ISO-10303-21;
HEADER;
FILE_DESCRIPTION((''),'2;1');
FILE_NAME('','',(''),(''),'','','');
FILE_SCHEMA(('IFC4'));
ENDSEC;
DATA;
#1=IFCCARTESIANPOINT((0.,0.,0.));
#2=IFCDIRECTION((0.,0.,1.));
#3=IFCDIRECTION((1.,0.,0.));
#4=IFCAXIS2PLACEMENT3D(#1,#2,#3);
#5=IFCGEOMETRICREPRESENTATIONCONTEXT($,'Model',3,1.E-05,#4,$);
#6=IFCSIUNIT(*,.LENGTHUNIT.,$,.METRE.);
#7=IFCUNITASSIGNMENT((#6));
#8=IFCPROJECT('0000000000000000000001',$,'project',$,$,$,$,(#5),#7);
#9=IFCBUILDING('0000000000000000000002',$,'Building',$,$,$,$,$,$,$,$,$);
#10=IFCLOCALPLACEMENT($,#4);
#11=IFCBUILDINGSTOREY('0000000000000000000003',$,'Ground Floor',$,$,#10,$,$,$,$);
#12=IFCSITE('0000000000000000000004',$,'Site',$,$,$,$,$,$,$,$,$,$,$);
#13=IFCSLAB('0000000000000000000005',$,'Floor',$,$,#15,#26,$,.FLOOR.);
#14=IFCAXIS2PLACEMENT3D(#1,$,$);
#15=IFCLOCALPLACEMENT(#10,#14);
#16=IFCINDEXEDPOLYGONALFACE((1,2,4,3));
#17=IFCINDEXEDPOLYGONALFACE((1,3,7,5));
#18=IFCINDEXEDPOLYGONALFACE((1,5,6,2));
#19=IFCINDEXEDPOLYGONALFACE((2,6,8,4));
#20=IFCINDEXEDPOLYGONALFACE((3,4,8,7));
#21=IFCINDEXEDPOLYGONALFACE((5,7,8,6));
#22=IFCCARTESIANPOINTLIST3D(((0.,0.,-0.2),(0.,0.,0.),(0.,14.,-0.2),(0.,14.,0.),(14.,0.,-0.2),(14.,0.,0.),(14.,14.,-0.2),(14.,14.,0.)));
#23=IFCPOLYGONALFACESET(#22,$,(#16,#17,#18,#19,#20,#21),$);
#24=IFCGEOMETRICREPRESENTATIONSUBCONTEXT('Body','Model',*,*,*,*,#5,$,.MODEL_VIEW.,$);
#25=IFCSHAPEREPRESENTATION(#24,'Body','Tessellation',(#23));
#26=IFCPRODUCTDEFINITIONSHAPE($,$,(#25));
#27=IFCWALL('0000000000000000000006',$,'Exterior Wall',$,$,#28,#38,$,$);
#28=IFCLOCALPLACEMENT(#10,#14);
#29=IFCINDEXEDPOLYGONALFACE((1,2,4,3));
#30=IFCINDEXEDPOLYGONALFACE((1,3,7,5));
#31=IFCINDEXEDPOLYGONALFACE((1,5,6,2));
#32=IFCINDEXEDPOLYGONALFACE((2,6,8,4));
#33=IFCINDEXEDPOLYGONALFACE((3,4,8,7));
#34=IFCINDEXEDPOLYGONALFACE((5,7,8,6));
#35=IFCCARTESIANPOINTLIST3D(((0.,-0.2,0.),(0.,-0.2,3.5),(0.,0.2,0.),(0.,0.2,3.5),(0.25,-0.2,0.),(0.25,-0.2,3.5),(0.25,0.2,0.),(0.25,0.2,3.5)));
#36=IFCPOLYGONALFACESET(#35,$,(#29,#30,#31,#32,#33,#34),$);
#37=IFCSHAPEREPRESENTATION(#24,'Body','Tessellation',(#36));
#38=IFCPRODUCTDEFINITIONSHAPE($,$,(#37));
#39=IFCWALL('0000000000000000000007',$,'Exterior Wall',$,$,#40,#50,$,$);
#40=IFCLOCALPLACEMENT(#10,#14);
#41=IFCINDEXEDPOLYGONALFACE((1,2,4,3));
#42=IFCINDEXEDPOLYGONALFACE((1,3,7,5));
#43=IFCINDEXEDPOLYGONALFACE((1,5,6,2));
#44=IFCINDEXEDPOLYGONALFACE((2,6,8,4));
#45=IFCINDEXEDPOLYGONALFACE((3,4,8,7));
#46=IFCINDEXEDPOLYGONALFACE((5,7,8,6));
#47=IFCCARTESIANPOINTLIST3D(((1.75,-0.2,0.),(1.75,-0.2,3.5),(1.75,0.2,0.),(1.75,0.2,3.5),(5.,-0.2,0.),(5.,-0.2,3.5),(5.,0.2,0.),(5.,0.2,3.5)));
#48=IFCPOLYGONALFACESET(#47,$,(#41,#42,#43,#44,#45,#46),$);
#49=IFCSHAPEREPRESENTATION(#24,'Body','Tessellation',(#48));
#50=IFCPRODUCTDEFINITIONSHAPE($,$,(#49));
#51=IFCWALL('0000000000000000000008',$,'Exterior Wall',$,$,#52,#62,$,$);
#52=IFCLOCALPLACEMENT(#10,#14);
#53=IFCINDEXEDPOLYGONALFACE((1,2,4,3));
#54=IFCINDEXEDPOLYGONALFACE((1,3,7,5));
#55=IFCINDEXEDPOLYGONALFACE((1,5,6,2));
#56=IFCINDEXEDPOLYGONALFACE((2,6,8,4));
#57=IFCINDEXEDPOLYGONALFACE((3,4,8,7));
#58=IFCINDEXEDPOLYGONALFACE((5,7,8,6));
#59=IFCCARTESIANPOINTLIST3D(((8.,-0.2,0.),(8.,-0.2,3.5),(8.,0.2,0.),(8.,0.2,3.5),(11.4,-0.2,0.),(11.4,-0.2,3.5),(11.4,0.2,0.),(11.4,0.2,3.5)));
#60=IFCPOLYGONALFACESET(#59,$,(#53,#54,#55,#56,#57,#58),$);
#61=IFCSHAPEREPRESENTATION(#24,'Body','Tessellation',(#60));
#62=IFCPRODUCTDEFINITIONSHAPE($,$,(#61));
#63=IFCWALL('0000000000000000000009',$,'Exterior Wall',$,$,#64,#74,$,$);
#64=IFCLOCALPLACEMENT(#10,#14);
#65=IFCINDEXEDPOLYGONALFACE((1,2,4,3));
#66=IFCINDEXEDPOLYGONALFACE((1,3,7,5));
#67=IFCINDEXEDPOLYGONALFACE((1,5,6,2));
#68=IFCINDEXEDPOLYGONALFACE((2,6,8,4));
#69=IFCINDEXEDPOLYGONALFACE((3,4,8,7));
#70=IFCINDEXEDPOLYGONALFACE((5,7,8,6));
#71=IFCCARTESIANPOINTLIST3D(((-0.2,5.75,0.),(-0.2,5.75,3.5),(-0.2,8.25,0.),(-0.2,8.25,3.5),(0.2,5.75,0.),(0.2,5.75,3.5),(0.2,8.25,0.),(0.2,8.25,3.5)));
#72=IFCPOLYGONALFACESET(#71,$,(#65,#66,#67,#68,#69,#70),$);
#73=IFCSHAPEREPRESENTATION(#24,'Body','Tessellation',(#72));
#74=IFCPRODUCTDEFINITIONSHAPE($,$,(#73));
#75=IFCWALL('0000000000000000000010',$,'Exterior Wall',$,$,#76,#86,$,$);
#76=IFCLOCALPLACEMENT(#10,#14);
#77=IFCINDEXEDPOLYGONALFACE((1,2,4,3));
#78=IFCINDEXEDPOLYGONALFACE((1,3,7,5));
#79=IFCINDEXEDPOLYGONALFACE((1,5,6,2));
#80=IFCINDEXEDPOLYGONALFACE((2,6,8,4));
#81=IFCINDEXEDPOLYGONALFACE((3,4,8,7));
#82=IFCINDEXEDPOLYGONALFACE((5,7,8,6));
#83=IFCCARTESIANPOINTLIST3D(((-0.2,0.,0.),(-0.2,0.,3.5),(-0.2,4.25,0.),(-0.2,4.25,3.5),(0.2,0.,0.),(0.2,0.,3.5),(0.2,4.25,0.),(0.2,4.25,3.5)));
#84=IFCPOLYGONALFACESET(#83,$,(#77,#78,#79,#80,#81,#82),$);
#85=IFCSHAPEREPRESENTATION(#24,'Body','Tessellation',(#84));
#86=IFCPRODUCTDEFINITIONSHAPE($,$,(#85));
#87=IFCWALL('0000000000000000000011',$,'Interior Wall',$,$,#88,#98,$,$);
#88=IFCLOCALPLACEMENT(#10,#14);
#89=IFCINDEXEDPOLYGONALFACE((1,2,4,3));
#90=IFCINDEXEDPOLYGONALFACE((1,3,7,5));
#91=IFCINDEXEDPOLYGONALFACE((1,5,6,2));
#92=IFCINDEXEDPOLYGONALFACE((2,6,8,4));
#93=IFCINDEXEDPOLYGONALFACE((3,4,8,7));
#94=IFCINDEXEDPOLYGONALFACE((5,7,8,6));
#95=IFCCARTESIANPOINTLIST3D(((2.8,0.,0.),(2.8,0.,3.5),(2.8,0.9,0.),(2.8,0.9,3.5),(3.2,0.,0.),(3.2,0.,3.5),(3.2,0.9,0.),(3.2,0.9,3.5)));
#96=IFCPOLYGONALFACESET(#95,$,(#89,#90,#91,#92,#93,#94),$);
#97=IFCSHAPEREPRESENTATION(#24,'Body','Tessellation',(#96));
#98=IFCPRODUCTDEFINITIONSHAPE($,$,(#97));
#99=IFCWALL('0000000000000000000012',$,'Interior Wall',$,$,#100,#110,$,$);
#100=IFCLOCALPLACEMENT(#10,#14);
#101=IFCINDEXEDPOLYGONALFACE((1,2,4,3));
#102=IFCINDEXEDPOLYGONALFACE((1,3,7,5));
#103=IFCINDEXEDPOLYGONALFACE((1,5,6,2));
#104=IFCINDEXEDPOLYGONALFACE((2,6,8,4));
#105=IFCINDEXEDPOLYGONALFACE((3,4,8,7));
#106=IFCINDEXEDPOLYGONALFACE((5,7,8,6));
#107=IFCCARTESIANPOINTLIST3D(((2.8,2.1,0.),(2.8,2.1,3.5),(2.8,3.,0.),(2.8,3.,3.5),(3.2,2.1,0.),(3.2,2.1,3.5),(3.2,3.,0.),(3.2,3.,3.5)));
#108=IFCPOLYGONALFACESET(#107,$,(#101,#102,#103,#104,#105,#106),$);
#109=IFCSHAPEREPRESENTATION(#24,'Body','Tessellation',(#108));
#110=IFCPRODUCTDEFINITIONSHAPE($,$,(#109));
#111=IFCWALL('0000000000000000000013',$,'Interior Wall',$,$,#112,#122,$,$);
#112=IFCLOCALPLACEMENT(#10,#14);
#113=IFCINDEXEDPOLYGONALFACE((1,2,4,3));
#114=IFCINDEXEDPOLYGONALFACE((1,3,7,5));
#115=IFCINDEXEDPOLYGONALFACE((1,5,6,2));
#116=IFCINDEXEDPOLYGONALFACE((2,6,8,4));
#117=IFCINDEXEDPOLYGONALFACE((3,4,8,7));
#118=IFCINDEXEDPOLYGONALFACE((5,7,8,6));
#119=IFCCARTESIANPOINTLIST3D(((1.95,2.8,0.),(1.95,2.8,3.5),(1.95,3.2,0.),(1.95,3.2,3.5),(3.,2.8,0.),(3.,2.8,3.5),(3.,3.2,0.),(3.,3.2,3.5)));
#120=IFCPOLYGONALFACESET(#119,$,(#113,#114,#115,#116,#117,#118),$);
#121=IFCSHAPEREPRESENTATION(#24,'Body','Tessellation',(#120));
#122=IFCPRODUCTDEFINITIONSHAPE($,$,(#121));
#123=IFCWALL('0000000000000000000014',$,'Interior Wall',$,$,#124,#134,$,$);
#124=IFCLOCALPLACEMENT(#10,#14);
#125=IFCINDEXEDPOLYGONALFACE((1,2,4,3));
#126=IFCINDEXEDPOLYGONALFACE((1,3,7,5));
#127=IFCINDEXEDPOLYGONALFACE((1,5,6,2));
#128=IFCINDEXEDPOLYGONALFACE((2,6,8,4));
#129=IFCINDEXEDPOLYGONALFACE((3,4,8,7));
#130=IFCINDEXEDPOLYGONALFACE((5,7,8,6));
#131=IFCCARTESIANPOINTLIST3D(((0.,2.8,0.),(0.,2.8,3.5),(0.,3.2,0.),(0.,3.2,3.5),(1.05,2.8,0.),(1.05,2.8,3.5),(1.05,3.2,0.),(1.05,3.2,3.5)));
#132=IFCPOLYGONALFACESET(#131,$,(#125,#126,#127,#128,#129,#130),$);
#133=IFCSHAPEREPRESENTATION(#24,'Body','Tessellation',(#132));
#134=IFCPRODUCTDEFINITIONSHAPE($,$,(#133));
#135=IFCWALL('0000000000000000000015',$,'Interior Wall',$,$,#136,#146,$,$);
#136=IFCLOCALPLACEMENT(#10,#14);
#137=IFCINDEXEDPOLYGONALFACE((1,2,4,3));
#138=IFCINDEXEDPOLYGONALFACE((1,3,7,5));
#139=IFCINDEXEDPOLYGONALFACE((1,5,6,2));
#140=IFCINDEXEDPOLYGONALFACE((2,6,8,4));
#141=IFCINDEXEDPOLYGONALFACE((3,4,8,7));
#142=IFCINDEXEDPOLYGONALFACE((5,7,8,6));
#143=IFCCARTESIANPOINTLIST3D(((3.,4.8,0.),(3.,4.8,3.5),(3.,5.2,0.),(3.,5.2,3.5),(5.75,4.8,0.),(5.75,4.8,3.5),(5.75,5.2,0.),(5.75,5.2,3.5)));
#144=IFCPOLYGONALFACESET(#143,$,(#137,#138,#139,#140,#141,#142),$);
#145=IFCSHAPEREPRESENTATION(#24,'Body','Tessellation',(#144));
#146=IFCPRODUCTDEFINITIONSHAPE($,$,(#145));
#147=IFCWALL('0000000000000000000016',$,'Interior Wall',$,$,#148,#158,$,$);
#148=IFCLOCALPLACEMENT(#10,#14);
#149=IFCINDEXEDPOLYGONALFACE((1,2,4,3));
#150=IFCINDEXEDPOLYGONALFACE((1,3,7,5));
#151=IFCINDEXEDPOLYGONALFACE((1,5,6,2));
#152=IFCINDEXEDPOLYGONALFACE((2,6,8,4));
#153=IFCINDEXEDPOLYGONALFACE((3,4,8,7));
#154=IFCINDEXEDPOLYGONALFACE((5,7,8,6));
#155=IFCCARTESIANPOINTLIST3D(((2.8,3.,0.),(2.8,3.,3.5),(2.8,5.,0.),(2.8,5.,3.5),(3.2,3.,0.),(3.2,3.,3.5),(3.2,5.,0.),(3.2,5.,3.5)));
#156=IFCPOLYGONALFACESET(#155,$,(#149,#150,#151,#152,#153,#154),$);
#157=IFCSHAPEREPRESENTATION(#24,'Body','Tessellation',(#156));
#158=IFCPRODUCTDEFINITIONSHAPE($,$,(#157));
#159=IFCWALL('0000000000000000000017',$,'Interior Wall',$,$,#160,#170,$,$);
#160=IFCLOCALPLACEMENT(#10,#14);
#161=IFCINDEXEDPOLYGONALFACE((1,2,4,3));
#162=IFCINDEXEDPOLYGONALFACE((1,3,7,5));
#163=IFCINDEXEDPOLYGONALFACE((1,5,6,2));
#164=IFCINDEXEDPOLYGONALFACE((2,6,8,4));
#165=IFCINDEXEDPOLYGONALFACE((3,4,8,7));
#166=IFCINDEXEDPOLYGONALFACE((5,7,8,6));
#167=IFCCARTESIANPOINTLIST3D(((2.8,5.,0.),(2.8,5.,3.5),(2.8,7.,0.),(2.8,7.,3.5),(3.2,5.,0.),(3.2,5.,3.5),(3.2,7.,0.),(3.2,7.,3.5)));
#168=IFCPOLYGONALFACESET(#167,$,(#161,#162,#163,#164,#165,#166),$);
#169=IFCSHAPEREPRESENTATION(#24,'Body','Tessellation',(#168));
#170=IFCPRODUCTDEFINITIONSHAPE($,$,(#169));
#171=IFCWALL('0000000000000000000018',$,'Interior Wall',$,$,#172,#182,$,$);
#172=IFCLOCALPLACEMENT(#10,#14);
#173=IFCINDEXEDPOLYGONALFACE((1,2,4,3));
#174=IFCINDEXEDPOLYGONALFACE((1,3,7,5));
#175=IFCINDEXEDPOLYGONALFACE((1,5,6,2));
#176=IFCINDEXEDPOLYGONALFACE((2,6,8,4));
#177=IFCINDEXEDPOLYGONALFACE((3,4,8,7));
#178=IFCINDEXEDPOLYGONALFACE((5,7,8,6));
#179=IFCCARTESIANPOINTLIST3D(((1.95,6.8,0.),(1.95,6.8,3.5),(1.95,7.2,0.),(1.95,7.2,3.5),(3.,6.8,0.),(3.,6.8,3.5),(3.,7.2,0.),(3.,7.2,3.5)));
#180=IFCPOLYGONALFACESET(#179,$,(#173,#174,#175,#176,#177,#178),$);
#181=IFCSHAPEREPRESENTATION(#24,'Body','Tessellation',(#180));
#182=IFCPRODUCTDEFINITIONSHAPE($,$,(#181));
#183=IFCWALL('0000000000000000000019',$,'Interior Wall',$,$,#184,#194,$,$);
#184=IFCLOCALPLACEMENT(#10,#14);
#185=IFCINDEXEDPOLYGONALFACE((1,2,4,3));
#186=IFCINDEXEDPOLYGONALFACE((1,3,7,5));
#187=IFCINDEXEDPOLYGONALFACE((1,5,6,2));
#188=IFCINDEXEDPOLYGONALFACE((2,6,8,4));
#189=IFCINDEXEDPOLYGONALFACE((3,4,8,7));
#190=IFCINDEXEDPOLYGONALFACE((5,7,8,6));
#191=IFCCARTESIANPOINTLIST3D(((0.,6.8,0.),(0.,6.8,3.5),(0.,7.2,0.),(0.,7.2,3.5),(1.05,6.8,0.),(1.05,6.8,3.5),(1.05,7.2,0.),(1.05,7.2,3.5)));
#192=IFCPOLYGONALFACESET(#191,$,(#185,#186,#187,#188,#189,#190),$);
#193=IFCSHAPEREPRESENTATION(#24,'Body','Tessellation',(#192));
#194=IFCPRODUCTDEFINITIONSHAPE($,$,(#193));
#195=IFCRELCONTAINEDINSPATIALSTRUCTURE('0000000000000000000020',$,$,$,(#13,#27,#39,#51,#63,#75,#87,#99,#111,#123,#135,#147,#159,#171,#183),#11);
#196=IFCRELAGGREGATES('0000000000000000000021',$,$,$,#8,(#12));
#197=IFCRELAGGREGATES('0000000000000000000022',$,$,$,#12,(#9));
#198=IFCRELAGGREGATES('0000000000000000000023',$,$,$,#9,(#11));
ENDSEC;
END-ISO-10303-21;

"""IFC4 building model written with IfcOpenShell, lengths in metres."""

from ifc_helpers import new_model, si_unit, frame, origin_with_axes, place, context, subcontext, project, spatial, indexed_curve, outline, extrude, element, save


model = new_model("IFC4")

# Units and contexts
model_context = context("Model", 3, precision=1e-05, world=origin_with_axes())
body_context = subcontext(model_context, "Body", "Model", "MODEL_VIEW")
ifc_project = project(units=[si_unit("LENGTHUNIT", "METRE")], contexts=[model_context])

# Site, building, storey
site = spatial("IfcSite", under=ifc_project, Name="Site")
building = spatial("IfcBuilding", under=site, Name="Building")
storey_placement = place(None, origin_with_axes())
storey = spatial("IfcBuildingStorey", under=building, at=storey_placement, Name="Ground Floor")

# Slab
slab_placement = place(storey_placement, frame((0.0, 0.0, -0.2), z_axis=(0.0, 0.0, 1.0), x_axis=(1.0, 0.0, 0.0)))
element("IfcSlab", 1, at=slab_placement, inside=storey, Name="Floor", PredefinedType="FLOOR", context=body_context, shape_type="SweptSolid", body=[
    extrude(outline(indexed_curve([(0.0, 0.0), (14.0, 0.0), (14.0, 14.0), (0.0, 14.0)])), None, (0.0, 0.0, 1.0), 0.2),
])

# Walls
wall_1_placement = place(storey_placement, origin_with_axes())
element("IfcWall", 2, at=wall_1_placement, inside=storey, Name="Exterior Wall", context=body_context, shape_type="SweptSolid", body=[
    extrude(outline(indexed_curve([(0.0, 0.0), (0.0, 0.4), (0.25, 0.4), (0.25, 0.0), (0.0, 0.0)], self_intersect=False)), frame((0.0, -0.2, 0.0), z_axis=(0.0, 0.0, 1.0), x_axis=(1.0, 0.0, 0.0)), (0.0, 0.0, 1.0), 3.5),
])
wall_2_placement = place(storey_placement, frame((1.75, 0.0, 0.0), z_axis=(0.0, 0.0, 1.0), x_axis=(1.0, 0.0, 0.0)))
element("IfcWall", 3, at=wall_2_placement, inside=storey, Name="Exterior Wall", context=body_context, shape_type="SweptSolid", body=[
    extrude(outline(indexed_curve([(0.0, 0.0), (0.0, 0.4), (3.25, 0.4), (3.25, 0.0), (0.0, 0.0)], self_intersect=False)), frame((0.0, -0.2, 0.0), z_axis=(0.0, 0.0, 1.0), x_axis=(1.0, 0.0, 0.0)), (0.0, 0.0, 1.0), 3.5),
])
wall_3_placement = place(storey_placement, frame((8.0, 0.0, 0.0), z_axis=(0.0, 0.0, 1.0), x_axis=(1.0, 0.0, 0.0)))
element("IfcWall", 4, at=wall_3_placement, inside=storey, Name="Exterior Wall", context=body_context, shape_type="SweptSolid", body=[
    extrude(outline(indexed_curve([(0.0, 0.0), (0.0, 0.4), (3.4, 0.4), (3.4, 0.0), (0.0, 0.0)], self_intersect=False)), frame((0.0, -0.2, 0.0), z_axis=(0.0, 0.0, 1.0), x_axis=(1.0, 0.0, 0.0)), (0.0, 0.0, 1.0), 3.5),
])
wall_4_placement = place(storey_placement, frame((0.0, 8.25, 0.0), z_axis=(0.0, 0.0, 1.0), x_axis=(0.0, -1.0, 0.0)))
element("IfcWall", 5, at=wall_4_placement, inside=storey, Name="Exterior Wall", context=body_context, shape_type="SweptSolid", body=[
    extrude(outline(indexed_curve([(0.0, 0.0), (0.0, 0.4), (2.5, 0.4), (2.5, 0.0), (0.0, 0.0)], self_intersect=False)), frame((0.0, -0.2, 0.0), z_axis=(0.0, 0.0, 1.0), x_axis=(1.0, 0.0, 0.0)), (0.0, 0.0, 1.0), 3.5),
])
wall_5_placement = place(storey_placement, frame((0.0, 4.25, 0.0), z_axis=(0.0, 0.0, 1.0), x_axis=(0.0, -1.0, 0.0)))
element("IfcWall", 6, at=wall_5_placement, inside=storey, Name="Exterior Wall", context=body_context, shape_type="SweptSolid", body=[
    extrude(outline(indexed_curve([(0.0, 0.0), (0.0, 0.4), (4.25, 0.4), (4.25, 0.0), (0.0, 0.0)], self_intersect=False)), frame((0.0, -0.2, 0.0), z_axis=(0.0, 0.0, 1.0), x_axis=(1.0, 0.0, 0.0)), (0.0, 0.0, 1.0), 3.5),
])
wall_6_placement = place(storey_placement, frame((3.0, 0.0, 0.0), z_axis=(0.0, 0.0, 1.0), x_axis=(0.0, 1.0, 0.0)))
element("IfcWall", 7, at=wall_6_placement, inside=storey, Name="Interior Wall", context=body_context, shape_type="SweptSolid", body=[
    extrude(outline(indexed_curve([(0.0, 0.0), (0.0, 0.4), (0.9, 0.4), (0.9, 0.0), (0.0, 0.0)], self_intersect=False)), frame((0.0, -0.2, 0.0), z_axis=(0.0, 0.0, 1.0), x_axis=(1.0, 0.0, 0.0)), (0.0, 0.0, 1.0), 3.5),
])
wall_7_placement = place(storey_placement, frame((3.0, 2.1, 0.0), z_axis=(0.0, 0.0, 1.0), x_axis=(0.0, 1.0, 0.0)))
element("IfcWall", 8, at=wall_7_placement, inside=storey, Name="Interior Wall", context=body_context, shape_type="SweptSolid", body=[
    extrude(outline(indexed_curve([(0.0, 0.0), (0.0, 0.4), (0.9, 0.4), (0.9, 0.0), (0.0, 0.0)], self_intersect=False)), frame((0.0, -0.2, 0.0), z_axis=(0.0, 0.0, 1.0), x_axis=(1.0, 0.0, 0.0)), (0.0, 0.0, 1.0), 3.5),
])
for number, where, z_axis, x_axis, name in (
    (9, (3.0, 3.0, 0.0), (0.0, 0.0, 1.0), (-1.0, 0.0, 0.0), "Interior Wall"),
    (10, (1.05, 3.0, 0.0), (0.0, 0.0, 1.0), (-1.0, 0.0, 0.0), "Interior Wall"),
):
    element("IfcWall", number, at=place(storey_placement, frame(where, z_axis=z_axis, x_axis=x_axis)), inside=storey, Name=name, context=body_context, shape_type="SweptSolid", body=[
        extrude(outline(indexed_curve([(0.0, 0.0), (0.0, 0.4), (1.05, 0.4), (1.05, 0.0), (0.0, 0.0)], self_intersect=False)), frame((0.0, -0.2, 0.0), z_axis=(0.0, 0.0, 1.0), x_axis=(1.0, 0.0, 0.0)), (0.0, 0.0, 1.0), 3.5),
    ])
wall_8_placement = place(storey_placement, frame((5.75, 5.0, 0.0), z_axis=(0.0, 0.0, 1.0), x_axis=(-1.0, 0.0, 0.0)))
element("IfcWall", 11, at=wall_8_placement, inside=storey, Name="Interior Wall", context=body_context, shape_type="SweptSolid", body=[
    extrude(outline(indexed_curve([(0.0, 0.0), (0.0, 0.4), (2.75, 0.4), (2.75, 0.0), (0.0, 0.0)], self_intersect=False)), frame((0.0, -0.2, 0.0), z_axis=(0.0, 0.0, 1.0), x_axis=(1.0, 0.0, 0.0)), (0.0, 0.0, 1.0), 3.5),
])
for number, where, z_axis, x_axis, name in (
    (12, (3.0, 5.0, 0.0), (0.0, 0.0, 1.0), (0.0, -1.0, 0.0), "Interior Wall"),
    (13, (3.0, 5.0, 0.0), (0.0, 0.0, 1.0), (0.0, 1.0, 0.0), "Interior Wall"),
):
    element("IfcWall", number, at=place(storey_placement, frame(where, z_axis=z_axis, x_axis=x_axis)), inside=storey, Name=name, context=body_context, shape_type="SweptSolid", body=[
        extrude(outline(indexed_curve([(0.0, 0.0), (0.0, 0.4), (2.0, 0.4), (2.0, 0.0), (0.0, 0.0)], self_intersect=False)), frame((0.0, -0.2, 0.0), z_axis=(0.0, 0.0, 1.0), x_axis=(1.0, 0.0, 0.0)), (0.0, 0.0, 1.0), 3.5),
    ])
for number, where, z_axis, x_axis, name in (
    (14, (3.0, 7.0, 0.0), (0.0, 0.0, 1.0), (-1.0, 0.0, 0.0), "Interior Wall"),
    (15, (1.05, 7.0, 0.0), (0.0, 0.0, 1.0), (-1.0, 0.0, 0.0), "Interior Wall"),
):
    element("IfcWall", number, at=place(storey_placement, frame(where, z_axis=z_axis, x_axis=x_axis)), inside=storey, Name=name, context=body_context, shape_type="SweptSolid", body=[
        extrude(outline(indexed_curve([(0.0, 0.0), (0.0, 0.4), (1.05, 0.4), (1.05, 0.0), (0.0, 0.0)], self_intersect=False)), frame((0.0, -0.2, 0.0), z_axis=(0.0, 0.0, 1.0), x_axis=(1.0, 0.0, 0.0)), (0.0, 0.0, 1.0), 3.5),
    ])

save(model, "model.ifc")
